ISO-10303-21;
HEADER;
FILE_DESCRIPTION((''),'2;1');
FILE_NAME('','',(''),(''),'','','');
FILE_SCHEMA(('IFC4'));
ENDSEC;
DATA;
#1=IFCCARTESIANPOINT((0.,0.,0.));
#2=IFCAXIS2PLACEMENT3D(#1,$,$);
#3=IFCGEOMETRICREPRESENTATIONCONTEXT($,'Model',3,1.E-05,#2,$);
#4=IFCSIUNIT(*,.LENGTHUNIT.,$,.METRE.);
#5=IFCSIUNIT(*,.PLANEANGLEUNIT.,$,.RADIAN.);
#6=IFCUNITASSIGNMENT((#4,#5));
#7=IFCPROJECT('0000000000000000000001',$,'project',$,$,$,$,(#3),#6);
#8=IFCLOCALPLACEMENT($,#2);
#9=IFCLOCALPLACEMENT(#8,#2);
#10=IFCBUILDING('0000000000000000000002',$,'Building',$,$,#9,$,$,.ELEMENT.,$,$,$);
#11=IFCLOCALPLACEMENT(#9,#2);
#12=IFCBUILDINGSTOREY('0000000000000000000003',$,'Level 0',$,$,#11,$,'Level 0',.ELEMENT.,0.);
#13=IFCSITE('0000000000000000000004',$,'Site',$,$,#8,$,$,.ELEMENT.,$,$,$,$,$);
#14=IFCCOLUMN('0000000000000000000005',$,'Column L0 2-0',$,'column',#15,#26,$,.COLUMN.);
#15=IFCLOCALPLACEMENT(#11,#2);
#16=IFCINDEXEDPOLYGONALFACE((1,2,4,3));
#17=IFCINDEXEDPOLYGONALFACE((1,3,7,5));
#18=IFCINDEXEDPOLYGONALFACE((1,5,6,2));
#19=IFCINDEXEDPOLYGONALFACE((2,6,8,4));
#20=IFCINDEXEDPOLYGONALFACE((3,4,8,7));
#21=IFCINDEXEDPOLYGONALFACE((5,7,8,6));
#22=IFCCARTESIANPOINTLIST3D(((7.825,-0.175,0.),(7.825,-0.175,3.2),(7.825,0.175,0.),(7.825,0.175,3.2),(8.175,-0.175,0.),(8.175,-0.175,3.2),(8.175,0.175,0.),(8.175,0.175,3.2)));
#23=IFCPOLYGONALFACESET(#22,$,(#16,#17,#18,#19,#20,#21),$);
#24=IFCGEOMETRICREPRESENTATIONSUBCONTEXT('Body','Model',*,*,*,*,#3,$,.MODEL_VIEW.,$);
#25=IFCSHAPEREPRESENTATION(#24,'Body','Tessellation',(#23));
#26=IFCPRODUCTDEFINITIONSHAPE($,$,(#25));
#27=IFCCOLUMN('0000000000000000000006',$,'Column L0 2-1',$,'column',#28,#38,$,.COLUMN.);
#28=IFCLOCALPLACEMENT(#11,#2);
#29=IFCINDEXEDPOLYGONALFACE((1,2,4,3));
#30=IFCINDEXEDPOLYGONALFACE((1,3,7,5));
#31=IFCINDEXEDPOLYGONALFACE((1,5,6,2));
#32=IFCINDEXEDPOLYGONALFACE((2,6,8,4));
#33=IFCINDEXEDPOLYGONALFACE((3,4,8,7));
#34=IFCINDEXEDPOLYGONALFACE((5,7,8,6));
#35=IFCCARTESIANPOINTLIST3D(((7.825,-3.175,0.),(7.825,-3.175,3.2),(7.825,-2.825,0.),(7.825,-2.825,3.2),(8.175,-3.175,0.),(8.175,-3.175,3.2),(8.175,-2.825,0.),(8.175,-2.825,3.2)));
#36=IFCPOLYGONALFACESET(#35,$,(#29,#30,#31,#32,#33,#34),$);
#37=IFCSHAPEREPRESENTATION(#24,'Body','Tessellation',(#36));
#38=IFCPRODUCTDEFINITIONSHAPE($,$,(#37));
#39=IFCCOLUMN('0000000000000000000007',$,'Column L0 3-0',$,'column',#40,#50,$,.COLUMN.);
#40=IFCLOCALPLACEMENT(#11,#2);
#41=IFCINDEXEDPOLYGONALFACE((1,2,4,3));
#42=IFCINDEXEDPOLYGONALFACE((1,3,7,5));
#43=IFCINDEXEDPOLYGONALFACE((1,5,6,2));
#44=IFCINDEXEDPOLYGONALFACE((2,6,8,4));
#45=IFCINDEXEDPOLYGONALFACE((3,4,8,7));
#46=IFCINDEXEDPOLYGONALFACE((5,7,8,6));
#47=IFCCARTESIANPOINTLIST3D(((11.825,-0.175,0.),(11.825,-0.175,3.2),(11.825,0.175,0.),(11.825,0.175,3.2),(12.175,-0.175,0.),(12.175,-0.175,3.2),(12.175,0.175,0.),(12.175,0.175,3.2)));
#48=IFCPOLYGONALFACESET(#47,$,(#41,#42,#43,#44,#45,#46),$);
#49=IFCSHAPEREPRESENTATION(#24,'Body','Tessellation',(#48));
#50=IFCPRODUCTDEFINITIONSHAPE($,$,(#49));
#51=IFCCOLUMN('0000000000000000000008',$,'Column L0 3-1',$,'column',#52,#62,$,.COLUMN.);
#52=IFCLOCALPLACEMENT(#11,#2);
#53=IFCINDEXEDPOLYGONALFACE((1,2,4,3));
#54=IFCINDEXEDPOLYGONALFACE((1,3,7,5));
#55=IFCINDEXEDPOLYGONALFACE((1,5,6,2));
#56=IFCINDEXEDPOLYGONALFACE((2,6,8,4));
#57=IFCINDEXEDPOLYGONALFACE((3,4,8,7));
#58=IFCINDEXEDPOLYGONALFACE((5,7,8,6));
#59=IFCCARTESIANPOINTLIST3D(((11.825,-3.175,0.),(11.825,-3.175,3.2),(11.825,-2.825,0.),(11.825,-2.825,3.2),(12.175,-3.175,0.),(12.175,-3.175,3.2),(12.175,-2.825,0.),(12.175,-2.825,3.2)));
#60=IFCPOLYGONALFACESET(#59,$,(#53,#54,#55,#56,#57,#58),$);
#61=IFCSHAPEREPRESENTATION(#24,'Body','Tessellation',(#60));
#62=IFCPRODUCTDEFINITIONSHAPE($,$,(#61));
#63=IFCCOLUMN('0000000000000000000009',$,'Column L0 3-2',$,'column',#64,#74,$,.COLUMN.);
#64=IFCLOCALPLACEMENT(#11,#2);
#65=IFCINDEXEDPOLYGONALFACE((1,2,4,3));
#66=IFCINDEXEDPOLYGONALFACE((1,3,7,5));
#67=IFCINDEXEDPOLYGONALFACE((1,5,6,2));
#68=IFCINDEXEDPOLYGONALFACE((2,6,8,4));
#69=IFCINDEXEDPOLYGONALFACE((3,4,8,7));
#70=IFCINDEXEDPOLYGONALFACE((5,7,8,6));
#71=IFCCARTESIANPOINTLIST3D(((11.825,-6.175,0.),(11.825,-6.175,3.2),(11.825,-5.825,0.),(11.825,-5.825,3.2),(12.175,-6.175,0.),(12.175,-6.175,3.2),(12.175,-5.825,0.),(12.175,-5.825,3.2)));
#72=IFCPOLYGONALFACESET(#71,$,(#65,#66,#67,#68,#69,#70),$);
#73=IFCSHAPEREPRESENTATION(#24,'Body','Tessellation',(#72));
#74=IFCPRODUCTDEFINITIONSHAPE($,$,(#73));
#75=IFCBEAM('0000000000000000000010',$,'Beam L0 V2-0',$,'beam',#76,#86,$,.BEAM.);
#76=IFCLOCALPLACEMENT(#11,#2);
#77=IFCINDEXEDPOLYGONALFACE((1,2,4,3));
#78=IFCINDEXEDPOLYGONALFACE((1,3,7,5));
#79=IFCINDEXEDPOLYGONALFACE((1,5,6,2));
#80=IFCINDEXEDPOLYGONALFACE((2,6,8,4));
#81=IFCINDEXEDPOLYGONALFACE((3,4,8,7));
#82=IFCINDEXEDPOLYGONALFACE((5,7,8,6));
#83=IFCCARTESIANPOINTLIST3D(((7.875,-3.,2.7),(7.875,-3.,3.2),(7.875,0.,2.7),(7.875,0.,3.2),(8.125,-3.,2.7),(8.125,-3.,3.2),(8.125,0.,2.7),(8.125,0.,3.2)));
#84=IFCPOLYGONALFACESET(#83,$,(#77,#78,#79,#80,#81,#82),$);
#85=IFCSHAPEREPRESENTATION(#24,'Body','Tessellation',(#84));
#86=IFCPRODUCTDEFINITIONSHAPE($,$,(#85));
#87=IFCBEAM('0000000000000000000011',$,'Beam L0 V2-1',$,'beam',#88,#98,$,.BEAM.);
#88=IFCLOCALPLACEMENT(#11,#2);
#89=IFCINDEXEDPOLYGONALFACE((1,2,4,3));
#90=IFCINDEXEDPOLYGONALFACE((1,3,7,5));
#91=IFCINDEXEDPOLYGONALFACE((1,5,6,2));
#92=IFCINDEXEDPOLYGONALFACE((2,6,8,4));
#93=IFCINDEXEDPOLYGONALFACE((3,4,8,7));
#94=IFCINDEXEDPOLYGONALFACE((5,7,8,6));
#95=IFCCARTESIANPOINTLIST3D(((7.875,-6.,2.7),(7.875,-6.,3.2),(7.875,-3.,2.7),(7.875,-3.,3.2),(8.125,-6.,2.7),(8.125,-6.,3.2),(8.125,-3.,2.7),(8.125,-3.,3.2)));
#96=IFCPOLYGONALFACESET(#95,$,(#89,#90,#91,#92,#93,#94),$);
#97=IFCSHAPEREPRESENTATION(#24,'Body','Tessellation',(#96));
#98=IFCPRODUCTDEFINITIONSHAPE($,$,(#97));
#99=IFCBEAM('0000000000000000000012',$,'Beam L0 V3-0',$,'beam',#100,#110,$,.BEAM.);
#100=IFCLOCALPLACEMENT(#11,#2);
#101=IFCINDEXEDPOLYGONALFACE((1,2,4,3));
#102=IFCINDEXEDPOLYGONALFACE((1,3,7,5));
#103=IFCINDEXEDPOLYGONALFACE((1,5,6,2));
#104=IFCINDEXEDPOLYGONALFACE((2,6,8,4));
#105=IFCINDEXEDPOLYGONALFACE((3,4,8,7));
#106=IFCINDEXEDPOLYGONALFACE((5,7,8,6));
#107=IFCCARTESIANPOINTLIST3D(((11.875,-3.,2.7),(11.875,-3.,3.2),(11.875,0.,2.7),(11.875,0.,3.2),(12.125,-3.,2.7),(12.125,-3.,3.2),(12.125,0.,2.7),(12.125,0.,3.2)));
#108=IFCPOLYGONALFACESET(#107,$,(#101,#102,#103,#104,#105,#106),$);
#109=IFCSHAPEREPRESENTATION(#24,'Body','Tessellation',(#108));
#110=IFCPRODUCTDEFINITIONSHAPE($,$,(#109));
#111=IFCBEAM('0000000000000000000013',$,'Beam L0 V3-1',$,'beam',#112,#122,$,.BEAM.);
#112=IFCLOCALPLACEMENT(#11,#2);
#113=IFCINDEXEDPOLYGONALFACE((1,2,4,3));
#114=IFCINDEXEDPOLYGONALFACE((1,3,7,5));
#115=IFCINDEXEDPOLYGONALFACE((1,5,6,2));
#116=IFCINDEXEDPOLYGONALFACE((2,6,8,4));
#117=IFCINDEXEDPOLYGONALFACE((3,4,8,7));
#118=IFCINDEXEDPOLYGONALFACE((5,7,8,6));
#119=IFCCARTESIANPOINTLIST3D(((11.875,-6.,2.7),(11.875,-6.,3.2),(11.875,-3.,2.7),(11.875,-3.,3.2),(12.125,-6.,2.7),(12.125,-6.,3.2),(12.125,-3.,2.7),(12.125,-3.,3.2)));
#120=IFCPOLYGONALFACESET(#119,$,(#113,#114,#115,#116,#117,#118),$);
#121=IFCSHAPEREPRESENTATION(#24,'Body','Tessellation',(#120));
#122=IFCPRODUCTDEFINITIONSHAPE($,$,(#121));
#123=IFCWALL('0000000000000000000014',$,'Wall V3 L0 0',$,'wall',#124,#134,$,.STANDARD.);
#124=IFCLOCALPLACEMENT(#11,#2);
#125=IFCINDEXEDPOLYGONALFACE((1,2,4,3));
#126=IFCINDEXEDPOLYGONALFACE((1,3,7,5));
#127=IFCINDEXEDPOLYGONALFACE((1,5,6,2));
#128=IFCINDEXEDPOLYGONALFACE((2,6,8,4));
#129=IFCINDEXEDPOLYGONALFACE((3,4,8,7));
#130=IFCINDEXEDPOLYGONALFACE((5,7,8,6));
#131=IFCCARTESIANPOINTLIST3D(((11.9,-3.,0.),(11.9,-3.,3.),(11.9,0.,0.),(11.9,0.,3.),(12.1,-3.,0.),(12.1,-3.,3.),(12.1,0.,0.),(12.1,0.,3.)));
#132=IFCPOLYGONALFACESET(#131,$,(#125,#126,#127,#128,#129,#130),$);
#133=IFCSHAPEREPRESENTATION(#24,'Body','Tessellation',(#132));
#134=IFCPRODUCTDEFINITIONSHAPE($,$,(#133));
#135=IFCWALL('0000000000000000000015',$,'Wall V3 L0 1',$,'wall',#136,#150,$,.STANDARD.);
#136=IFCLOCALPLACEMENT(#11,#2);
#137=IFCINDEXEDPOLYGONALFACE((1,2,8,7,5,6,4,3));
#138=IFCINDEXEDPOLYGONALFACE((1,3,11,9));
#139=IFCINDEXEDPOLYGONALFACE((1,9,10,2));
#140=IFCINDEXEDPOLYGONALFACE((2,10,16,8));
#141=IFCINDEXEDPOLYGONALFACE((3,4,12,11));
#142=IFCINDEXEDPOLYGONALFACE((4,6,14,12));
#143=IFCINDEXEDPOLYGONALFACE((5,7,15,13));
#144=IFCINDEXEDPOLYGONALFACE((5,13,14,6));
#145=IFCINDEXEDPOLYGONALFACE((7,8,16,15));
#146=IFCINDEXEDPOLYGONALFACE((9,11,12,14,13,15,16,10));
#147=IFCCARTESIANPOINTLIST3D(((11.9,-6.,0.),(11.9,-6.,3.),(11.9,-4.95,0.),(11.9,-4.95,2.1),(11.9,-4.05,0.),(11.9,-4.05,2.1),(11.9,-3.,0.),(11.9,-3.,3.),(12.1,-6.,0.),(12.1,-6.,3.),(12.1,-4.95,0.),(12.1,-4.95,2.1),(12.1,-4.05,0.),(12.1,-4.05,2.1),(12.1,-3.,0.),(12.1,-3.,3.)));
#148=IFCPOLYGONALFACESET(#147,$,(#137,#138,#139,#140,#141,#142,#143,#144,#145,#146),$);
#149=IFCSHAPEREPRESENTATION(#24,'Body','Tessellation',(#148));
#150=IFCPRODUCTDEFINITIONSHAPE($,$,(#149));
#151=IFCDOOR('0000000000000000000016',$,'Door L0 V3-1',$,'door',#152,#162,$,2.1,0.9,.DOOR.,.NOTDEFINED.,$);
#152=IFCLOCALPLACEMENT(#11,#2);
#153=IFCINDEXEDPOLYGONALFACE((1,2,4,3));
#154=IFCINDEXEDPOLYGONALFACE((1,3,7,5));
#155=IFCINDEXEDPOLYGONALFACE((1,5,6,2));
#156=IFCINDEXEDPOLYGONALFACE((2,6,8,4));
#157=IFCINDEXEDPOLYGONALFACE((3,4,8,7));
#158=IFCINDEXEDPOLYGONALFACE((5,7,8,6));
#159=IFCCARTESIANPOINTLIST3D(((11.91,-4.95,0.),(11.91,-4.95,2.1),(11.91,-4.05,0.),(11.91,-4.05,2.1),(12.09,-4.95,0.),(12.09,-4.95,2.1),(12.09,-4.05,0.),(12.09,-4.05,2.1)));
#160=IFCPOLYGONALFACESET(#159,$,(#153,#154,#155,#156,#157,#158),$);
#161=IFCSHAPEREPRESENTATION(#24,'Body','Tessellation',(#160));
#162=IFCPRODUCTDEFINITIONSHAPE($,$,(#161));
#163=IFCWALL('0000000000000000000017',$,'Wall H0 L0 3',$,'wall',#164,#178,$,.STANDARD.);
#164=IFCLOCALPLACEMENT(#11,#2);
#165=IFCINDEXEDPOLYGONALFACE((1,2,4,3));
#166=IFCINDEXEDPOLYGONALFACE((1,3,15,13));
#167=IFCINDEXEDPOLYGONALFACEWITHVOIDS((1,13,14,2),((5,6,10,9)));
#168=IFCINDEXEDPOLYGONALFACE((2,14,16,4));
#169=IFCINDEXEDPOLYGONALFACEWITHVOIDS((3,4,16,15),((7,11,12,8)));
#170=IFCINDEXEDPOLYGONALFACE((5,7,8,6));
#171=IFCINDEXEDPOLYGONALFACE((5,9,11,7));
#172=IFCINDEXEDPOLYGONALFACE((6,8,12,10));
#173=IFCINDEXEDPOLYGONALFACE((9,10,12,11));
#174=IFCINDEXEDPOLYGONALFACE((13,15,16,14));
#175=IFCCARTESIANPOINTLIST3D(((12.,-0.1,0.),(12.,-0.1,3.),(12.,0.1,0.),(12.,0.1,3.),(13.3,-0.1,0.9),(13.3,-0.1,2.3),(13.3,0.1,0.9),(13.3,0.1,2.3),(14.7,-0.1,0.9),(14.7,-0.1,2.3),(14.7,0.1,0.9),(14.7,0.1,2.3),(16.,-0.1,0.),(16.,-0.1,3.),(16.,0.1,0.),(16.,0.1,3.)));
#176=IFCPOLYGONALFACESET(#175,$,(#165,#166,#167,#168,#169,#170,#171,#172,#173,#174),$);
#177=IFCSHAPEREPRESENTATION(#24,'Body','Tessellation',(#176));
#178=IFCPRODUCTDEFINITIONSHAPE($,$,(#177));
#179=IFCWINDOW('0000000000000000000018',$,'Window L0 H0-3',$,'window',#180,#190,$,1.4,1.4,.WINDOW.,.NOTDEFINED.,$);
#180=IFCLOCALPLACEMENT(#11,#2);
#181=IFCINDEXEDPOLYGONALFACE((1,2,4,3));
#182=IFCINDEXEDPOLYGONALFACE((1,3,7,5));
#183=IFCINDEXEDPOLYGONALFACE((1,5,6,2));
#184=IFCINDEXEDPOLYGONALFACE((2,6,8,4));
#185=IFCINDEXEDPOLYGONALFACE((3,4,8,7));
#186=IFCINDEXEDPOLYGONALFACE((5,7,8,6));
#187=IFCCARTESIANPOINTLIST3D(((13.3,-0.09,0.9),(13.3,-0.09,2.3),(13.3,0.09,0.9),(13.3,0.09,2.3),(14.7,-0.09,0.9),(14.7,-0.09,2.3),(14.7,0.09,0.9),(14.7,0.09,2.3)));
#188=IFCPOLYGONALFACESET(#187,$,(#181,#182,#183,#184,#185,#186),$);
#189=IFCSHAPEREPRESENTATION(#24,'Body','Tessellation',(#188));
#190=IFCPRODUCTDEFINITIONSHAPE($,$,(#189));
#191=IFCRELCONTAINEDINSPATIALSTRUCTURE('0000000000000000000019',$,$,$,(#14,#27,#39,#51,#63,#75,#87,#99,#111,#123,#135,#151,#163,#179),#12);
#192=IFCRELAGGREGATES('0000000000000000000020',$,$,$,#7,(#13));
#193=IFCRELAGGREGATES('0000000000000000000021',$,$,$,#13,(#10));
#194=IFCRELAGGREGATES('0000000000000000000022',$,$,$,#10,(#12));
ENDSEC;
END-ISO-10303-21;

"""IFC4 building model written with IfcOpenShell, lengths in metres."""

from ifc_helpers import new_model, si_unit, frame, frame_2d, origin, origin_2d, place, context, subcontext, project, spatial, rectangle, extrude, element, fill, save


model = new_model("IFC4")

# Units and contexts
model_context = context("Model", 3, precision=1e-05, world=origin())
body_context = subcontext(model_context, "Body", "Model", "MODEL_VIEW")
ifc_project = project(units=[si_unit("LENGTHUNIT", "METRE"), si_unit("PLANEANGLEUNIT", "RADIAN")], contexts=[model_context])

# Site, building, storey
site_placement = place(None, origin())
site = spatial("IfcSite", under=ifc_project, at=site_placement, Name="Site", CompositionType="ELEMENT")
building_placement = place(site_placement, origin())
building = spatial("IfcBuilding", under=site, at=building_placement, Name="Building", CompositionType="ELEMENT")
storey_placement = place(building_placement, origin())
storey = spatial("IfcBuildingStorey", under=building, at=storey_placement, Name="Level 0", LongName="Level 0", CompositionType="ELEMENT", Elevation=0.0)

# Columns
for number, where, name in (
    (1, (8.0, 0.0, 0.0), "Column L0 2-0"),
    (2, (8.0, -3.0, 0.0), "Column L0 2-1"),
    (3, (12.0, 0.0, 0.0), "Column L0 3-0"),
    (4, (12.0, -3.0, 0.0), "Column L0 3-1"),
    (5, (12.0, -6.0, 0.0), "Column L0 3-2"),
):
    element("IfcColumn", number, at=place(storey_placement, frame(where)), inside=storey, Name=name, ObjectType="column", PredefinedType="COLUMN", context=body_context, shape_type="SweptSolid", body=[
        extrude(rectangle(XDim=0.35, YDim=0.35, at=origin_2d()), origin(), (0.0, 0.0, 1.0), 3.2),
    ])

# Beams
for number, where, z_axis, x_axis, name in (
    (6, (8.0, 0.0, 2.95), (0.0, -1.0, 0.0), (0.0, 0.0, 1.0), "Beam L0 V2-0"),
    (7, (8.0, -3.0, 2.95), (0.0, -1.0, 0.0), (0.0, 0.0, 1.0), "Beam L0 V2-1"),
    (8, (12.0, 0.0, 2.95), (0.0, -1.0, 0.0), (0.0, 0.0, 1.0), "Beam L0 V3-0"),
    (9, (12.0, -3.0, 2.95), (0.0, -1.0, 0.0), (0.0, 0.0, 1.0), "Beam L0 V3-1"),
):
    element("IfcBeam", number, at=place(storey_placement, frame(where, z_axis=z_axis, x_axis=x_axis)), inside=storey, Name=name, ObjectType="beam", PredefinedType="BEAM", context=body_context, shape_type="SweptSolid", body=[
        extrude(rectangle(XDim=0.5, YDim=0.25, at=origin_2d()), origin(), (0.0, 0.0, 1.0), 3.0),
    ])

# Wall
wall_1_placement = place(storey_placement, frame((12.0, 0.0, 0.0), z_axis=(0.0, 0.0, 1.0), x_axis=(0.0, -1.0, 0.0)))
element("IfcWall", 10, at=wall_1_placement, inside=storey, Name="Wall V3 L0 0", ObjectType="wall", PredefinedType="STANDARD", context=body_context, shape_type="SweptSolid", body=[
    extrude(rectangle(XDim=3.0, YDim=0.2, at=frame_2d((1.5, 0.0))), origin(), (0.0, 0.0, 1.0), 3.0),
])

# Wall, opening, door
wall_2_placement = place(storey_placement, frame((12.0, -3.0, 0.0), z_axis=(0.0, 0.0, 1.0), x_axis=(0.0, -1.0, 0.0)))
wall_2 = element("IfcWall", 11, at=wall_2_placement, inside=storey, Name="Wall V3 L0 1", ObjectType="wall", PredefinedType="STANDARD", context=body_context, shape_type="SweptSolid", body=[
    extrude(rectangle(XDim=3.0, YDim=0.2, at=frame_2d((1.5, 0.0))), origin(), (0.0, 0.0, 1.0), 3.0),
])
opening_1_placement = place(storey_placement, frame((12.0, -4.5, 0.0), z_axis=(0.0, 0.0, 1.0), x_axis=(0.0, -1.0, 0.0)))
opening_1 = element("IfcOpeningElement", 12, at=opening_1_placement, cuts=wall_2, ObjectType="Opening", PredefinedType="OPENING", context=body_context, shape_type="SweptSolid", body=[
    extrude(rectangle(XDim=0.9, YDim=0.22, at=origin_2d()), origin(), (0.0, 0.0, 1.0), 2.1),
])
door_1_placement = place(storey_placement, frame((12.0, -4.5, 0.0), z_axis=(0.0, 0.0, 1.0), x_axis=(0.0, -1.0, 0.0)))
door_1 = element("IfcDoor", 13, at=door_1_placement, inside=storey, Name="Door L0 V3-1", ObjectType="door", OperationType="NOTDEFINED", OverallHeight=2.1, OverallWidth=0.9, PredefinedType="DOOR", context=body_context, shape_type="SweptSolid", body=[
    extrude(rectangle(XDim=0.9, YDim=0.18, at=origin_2d()), origin(), (0.0, 0.0, 1.0), 2.1),
])
fill(opening_1, door_1)

# Wall, opening, window
wall_3_placement = place(storey_placement, frame((12.0, 0.0, 0.0), z_axis=(0.0, 0.0, 1.0), x_axis=(1.0, 0.0, 0.0)))
wall_3 = element("IfcWall", 14, at=wall_3_placement, inside=storey, Name="Wall H0 L0 3", ObjectType="wall", PredefinedType="STANDARD", context=body_context, shape_type="SweptSolid", body=[
    extrude(rectangle(XDim=4.0, YDim=0.2, at=frame_2d((2.0, 0.0))), origin(), (0.0, 0.0, 1.0), 3.0),
])
opening_2_placement = place(storey_placement, frame((14.0, 0.0, 0.9), z_axis=(0.0, 0.0, 1.0), x_axis=(1.0, 0.0, 0.0)))
opening_2 = element("IfcOpeningElement", 15, at=opening_2_placement, cuts=wall_3, ObjectType="Opening", PredefinedType="OPENING", context=body_context, shape_type="SweptSolid", body=[
    extrude(rectangle(XDim=1.4, YDim=0.22, at=origin_2d()), origin(), (0.0, 0.0, 1.0), 1.4),
])
window_placement = place(storey_placement, frame((14.0, 0.0, 0.9), z_axis=(0.0, 0.0, 1.0), x_axis=(1.0, 0.0, 0.0)))
window = element("IfcWindow", 16, at=window_placement, inside=storey, Name="Window L0 H0-3", ObjectType="window", OverallHeight=1.4, OverallWidth=1.4, PartitioningType="NOTDEFINED", PredefinedType="WINDOW", context=body_context, shape_type="SweptSolid", body=[
    extrude(rectangle(XDim=1.4, YDim=0.18, at=origin_2d()), origin(), (0.0, 0.0, 1.0), 1.4),
])
fill(opening_2, window)

save(model, "model.ifc")
